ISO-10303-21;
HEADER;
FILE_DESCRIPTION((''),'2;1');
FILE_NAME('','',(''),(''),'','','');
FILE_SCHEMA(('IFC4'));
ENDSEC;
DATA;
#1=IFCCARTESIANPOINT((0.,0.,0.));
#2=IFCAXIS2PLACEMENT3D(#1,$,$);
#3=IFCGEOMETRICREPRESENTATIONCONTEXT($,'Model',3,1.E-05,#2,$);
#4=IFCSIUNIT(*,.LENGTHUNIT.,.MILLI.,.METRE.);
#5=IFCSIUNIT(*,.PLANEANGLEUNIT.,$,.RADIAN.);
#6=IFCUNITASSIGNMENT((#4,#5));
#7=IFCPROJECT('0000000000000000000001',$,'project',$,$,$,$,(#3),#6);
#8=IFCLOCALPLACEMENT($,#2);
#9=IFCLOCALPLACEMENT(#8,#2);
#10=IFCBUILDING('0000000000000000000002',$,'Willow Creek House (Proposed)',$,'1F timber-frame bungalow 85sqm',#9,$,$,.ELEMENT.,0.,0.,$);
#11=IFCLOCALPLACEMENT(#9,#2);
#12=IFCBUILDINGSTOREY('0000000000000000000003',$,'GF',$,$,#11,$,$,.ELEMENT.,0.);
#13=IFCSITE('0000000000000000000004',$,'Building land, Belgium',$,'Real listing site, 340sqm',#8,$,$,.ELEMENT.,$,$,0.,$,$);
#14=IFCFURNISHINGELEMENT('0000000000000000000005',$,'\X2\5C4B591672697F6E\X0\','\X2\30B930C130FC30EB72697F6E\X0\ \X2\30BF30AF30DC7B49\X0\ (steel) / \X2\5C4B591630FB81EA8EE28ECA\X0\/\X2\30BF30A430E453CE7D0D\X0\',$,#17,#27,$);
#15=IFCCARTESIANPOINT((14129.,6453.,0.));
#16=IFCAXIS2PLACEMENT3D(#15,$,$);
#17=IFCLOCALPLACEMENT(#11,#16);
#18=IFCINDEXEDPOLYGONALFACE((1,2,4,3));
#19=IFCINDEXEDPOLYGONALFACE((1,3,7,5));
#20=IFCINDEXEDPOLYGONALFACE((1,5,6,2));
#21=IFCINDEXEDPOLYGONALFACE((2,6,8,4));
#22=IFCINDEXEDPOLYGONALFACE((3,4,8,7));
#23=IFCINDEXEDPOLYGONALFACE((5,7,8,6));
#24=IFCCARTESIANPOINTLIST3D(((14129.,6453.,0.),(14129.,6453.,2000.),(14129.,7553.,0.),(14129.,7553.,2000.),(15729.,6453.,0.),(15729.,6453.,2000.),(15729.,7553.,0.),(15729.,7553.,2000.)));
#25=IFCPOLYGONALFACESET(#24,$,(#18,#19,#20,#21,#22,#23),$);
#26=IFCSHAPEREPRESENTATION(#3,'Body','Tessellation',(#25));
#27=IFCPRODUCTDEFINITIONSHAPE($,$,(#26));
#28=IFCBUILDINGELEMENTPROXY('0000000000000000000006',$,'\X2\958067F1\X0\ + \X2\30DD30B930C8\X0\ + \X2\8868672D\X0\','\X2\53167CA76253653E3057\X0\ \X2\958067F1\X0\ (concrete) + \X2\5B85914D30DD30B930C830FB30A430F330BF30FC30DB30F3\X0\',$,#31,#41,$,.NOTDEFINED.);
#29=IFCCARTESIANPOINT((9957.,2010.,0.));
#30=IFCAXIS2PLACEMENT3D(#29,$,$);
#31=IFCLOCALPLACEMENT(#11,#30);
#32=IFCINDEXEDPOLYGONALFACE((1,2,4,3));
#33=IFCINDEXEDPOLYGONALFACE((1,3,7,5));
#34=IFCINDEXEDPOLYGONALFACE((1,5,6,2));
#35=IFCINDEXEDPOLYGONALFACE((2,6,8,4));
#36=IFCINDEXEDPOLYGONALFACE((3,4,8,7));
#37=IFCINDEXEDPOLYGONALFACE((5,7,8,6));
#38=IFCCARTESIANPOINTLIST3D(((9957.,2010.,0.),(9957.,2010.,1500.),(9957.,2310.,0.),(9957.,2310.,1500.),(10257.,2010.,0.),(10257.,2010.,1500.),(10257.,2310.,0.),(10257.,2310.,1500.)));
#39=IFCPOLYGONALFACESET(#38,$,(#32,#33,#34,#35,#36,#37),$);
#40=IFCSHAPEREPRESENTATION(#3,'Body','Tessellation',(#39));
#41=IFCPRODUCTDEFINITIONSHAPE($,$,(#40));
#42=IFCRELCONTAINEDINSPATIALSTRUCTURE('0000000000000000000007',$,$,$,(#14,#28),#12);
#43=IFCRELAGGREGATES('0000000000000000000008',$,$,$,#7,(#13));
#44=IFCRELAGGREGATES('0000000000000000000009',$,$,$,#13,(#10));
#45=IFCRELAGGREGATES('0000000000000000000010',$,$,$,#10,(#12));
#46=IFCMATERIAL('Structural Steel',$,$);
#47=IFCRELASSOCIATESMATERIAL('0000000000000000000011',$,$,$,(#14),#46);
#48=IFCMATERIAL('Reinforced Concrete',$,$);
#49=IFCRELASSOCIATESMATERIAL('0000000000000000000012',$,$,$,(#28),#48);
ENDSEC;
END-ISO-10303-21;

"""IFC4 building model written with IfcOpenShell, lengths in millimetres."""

from ifc_helpers import new_model, si_unit, frame, frame_2d, origin, place, context, project, spatial, rectangle, extrude, material, element, save


model = new_model("IFC4")

# Units and contexts
model_context = context("Model", 3, precision=1e-05, world=origin())
ifc_project = project(units=[si_unit("LENGTHUNIT", "METRE", prefix="MILLI"), si_unit("PLANEANGLEUNIT", "RADIAN")], contexts=[model_context])

# Site, building, storey
site_placement = place(None, origin())
site = spatial("IfcSite", under=ifc_project, at=site_placement, Name="Building land, Belgium", ObjectType="Real listing site, 340sqm", CompositionType="ELEMENT", RefElevation=0.0)
building_placement = place(site_placement, origin())
building = spatial("IfcBuilding", under=site, at=building_placement, Name="Willow Creek House (Proposed)", ObjectType="1F timber-frame bungalow 85sqm", CompositionType="ELEMENT", ElevationOfRefHeight=0.0, ElevationOfTerrain=0.0)
storey_placement = place(building_placement, origin())
storey = spatial("IfcBuildingStorey", under=building, at=storey_placement, Name="GF", CompositionType="ELEMENT", Elevation=0.0)

# Shared definitions
ifc_material_1 = material(Name="Reinforced Concrete")

# Shared definitions
ifc_material_2 = material(Name="Structural Steel")

# Furnishing element
furnishing_1_placement = place(storey_placement, frame((14129.0, 6453.0, 0.0)))
element("IfcFurnishingElement", 1, at=furnishing_1_placement, inside=storey, material=ifc_material_2, Name="屋外物置", Description="スチール物置 タクボ等 (steel) / 屋外・自転車/タイヤ収納", context=model_context, shape_type="SweptSolid", body=[
    extrude(rectangle(XDim=1600.0, YDim=1100.0, at=frame_2d((800.0, 550.0))), frame((14129.0, 6453.0, 0.0)), (0.0, 0.0, 1.0), 2000.0),
])

# Building element proxy
proxy_placement = place(storey_placement, frame((9957.0, 2010.0, 0.0)))
element("IfcBuildingElementProxy", 2, at=proxy_placement, inside=storey, material=ifc_material_1, Name="門柱 + ポスト + 表札", Description="化粧打放し 門柱 (concrete) + 宅配ポスト・インターホン", PredefinedType="NOTDEFINED", context=model_context, shape_type="SweptSolid", body=[
    extrude(rectangle(XDim=300.0, YDim=300.0, at=frame_2d((150.0, 150.0))), frame((9957.0, 2010.0, 0.0)), (0.0, 0.0, 1.0), 1500.0),
])

save(model, "model.ifc")
